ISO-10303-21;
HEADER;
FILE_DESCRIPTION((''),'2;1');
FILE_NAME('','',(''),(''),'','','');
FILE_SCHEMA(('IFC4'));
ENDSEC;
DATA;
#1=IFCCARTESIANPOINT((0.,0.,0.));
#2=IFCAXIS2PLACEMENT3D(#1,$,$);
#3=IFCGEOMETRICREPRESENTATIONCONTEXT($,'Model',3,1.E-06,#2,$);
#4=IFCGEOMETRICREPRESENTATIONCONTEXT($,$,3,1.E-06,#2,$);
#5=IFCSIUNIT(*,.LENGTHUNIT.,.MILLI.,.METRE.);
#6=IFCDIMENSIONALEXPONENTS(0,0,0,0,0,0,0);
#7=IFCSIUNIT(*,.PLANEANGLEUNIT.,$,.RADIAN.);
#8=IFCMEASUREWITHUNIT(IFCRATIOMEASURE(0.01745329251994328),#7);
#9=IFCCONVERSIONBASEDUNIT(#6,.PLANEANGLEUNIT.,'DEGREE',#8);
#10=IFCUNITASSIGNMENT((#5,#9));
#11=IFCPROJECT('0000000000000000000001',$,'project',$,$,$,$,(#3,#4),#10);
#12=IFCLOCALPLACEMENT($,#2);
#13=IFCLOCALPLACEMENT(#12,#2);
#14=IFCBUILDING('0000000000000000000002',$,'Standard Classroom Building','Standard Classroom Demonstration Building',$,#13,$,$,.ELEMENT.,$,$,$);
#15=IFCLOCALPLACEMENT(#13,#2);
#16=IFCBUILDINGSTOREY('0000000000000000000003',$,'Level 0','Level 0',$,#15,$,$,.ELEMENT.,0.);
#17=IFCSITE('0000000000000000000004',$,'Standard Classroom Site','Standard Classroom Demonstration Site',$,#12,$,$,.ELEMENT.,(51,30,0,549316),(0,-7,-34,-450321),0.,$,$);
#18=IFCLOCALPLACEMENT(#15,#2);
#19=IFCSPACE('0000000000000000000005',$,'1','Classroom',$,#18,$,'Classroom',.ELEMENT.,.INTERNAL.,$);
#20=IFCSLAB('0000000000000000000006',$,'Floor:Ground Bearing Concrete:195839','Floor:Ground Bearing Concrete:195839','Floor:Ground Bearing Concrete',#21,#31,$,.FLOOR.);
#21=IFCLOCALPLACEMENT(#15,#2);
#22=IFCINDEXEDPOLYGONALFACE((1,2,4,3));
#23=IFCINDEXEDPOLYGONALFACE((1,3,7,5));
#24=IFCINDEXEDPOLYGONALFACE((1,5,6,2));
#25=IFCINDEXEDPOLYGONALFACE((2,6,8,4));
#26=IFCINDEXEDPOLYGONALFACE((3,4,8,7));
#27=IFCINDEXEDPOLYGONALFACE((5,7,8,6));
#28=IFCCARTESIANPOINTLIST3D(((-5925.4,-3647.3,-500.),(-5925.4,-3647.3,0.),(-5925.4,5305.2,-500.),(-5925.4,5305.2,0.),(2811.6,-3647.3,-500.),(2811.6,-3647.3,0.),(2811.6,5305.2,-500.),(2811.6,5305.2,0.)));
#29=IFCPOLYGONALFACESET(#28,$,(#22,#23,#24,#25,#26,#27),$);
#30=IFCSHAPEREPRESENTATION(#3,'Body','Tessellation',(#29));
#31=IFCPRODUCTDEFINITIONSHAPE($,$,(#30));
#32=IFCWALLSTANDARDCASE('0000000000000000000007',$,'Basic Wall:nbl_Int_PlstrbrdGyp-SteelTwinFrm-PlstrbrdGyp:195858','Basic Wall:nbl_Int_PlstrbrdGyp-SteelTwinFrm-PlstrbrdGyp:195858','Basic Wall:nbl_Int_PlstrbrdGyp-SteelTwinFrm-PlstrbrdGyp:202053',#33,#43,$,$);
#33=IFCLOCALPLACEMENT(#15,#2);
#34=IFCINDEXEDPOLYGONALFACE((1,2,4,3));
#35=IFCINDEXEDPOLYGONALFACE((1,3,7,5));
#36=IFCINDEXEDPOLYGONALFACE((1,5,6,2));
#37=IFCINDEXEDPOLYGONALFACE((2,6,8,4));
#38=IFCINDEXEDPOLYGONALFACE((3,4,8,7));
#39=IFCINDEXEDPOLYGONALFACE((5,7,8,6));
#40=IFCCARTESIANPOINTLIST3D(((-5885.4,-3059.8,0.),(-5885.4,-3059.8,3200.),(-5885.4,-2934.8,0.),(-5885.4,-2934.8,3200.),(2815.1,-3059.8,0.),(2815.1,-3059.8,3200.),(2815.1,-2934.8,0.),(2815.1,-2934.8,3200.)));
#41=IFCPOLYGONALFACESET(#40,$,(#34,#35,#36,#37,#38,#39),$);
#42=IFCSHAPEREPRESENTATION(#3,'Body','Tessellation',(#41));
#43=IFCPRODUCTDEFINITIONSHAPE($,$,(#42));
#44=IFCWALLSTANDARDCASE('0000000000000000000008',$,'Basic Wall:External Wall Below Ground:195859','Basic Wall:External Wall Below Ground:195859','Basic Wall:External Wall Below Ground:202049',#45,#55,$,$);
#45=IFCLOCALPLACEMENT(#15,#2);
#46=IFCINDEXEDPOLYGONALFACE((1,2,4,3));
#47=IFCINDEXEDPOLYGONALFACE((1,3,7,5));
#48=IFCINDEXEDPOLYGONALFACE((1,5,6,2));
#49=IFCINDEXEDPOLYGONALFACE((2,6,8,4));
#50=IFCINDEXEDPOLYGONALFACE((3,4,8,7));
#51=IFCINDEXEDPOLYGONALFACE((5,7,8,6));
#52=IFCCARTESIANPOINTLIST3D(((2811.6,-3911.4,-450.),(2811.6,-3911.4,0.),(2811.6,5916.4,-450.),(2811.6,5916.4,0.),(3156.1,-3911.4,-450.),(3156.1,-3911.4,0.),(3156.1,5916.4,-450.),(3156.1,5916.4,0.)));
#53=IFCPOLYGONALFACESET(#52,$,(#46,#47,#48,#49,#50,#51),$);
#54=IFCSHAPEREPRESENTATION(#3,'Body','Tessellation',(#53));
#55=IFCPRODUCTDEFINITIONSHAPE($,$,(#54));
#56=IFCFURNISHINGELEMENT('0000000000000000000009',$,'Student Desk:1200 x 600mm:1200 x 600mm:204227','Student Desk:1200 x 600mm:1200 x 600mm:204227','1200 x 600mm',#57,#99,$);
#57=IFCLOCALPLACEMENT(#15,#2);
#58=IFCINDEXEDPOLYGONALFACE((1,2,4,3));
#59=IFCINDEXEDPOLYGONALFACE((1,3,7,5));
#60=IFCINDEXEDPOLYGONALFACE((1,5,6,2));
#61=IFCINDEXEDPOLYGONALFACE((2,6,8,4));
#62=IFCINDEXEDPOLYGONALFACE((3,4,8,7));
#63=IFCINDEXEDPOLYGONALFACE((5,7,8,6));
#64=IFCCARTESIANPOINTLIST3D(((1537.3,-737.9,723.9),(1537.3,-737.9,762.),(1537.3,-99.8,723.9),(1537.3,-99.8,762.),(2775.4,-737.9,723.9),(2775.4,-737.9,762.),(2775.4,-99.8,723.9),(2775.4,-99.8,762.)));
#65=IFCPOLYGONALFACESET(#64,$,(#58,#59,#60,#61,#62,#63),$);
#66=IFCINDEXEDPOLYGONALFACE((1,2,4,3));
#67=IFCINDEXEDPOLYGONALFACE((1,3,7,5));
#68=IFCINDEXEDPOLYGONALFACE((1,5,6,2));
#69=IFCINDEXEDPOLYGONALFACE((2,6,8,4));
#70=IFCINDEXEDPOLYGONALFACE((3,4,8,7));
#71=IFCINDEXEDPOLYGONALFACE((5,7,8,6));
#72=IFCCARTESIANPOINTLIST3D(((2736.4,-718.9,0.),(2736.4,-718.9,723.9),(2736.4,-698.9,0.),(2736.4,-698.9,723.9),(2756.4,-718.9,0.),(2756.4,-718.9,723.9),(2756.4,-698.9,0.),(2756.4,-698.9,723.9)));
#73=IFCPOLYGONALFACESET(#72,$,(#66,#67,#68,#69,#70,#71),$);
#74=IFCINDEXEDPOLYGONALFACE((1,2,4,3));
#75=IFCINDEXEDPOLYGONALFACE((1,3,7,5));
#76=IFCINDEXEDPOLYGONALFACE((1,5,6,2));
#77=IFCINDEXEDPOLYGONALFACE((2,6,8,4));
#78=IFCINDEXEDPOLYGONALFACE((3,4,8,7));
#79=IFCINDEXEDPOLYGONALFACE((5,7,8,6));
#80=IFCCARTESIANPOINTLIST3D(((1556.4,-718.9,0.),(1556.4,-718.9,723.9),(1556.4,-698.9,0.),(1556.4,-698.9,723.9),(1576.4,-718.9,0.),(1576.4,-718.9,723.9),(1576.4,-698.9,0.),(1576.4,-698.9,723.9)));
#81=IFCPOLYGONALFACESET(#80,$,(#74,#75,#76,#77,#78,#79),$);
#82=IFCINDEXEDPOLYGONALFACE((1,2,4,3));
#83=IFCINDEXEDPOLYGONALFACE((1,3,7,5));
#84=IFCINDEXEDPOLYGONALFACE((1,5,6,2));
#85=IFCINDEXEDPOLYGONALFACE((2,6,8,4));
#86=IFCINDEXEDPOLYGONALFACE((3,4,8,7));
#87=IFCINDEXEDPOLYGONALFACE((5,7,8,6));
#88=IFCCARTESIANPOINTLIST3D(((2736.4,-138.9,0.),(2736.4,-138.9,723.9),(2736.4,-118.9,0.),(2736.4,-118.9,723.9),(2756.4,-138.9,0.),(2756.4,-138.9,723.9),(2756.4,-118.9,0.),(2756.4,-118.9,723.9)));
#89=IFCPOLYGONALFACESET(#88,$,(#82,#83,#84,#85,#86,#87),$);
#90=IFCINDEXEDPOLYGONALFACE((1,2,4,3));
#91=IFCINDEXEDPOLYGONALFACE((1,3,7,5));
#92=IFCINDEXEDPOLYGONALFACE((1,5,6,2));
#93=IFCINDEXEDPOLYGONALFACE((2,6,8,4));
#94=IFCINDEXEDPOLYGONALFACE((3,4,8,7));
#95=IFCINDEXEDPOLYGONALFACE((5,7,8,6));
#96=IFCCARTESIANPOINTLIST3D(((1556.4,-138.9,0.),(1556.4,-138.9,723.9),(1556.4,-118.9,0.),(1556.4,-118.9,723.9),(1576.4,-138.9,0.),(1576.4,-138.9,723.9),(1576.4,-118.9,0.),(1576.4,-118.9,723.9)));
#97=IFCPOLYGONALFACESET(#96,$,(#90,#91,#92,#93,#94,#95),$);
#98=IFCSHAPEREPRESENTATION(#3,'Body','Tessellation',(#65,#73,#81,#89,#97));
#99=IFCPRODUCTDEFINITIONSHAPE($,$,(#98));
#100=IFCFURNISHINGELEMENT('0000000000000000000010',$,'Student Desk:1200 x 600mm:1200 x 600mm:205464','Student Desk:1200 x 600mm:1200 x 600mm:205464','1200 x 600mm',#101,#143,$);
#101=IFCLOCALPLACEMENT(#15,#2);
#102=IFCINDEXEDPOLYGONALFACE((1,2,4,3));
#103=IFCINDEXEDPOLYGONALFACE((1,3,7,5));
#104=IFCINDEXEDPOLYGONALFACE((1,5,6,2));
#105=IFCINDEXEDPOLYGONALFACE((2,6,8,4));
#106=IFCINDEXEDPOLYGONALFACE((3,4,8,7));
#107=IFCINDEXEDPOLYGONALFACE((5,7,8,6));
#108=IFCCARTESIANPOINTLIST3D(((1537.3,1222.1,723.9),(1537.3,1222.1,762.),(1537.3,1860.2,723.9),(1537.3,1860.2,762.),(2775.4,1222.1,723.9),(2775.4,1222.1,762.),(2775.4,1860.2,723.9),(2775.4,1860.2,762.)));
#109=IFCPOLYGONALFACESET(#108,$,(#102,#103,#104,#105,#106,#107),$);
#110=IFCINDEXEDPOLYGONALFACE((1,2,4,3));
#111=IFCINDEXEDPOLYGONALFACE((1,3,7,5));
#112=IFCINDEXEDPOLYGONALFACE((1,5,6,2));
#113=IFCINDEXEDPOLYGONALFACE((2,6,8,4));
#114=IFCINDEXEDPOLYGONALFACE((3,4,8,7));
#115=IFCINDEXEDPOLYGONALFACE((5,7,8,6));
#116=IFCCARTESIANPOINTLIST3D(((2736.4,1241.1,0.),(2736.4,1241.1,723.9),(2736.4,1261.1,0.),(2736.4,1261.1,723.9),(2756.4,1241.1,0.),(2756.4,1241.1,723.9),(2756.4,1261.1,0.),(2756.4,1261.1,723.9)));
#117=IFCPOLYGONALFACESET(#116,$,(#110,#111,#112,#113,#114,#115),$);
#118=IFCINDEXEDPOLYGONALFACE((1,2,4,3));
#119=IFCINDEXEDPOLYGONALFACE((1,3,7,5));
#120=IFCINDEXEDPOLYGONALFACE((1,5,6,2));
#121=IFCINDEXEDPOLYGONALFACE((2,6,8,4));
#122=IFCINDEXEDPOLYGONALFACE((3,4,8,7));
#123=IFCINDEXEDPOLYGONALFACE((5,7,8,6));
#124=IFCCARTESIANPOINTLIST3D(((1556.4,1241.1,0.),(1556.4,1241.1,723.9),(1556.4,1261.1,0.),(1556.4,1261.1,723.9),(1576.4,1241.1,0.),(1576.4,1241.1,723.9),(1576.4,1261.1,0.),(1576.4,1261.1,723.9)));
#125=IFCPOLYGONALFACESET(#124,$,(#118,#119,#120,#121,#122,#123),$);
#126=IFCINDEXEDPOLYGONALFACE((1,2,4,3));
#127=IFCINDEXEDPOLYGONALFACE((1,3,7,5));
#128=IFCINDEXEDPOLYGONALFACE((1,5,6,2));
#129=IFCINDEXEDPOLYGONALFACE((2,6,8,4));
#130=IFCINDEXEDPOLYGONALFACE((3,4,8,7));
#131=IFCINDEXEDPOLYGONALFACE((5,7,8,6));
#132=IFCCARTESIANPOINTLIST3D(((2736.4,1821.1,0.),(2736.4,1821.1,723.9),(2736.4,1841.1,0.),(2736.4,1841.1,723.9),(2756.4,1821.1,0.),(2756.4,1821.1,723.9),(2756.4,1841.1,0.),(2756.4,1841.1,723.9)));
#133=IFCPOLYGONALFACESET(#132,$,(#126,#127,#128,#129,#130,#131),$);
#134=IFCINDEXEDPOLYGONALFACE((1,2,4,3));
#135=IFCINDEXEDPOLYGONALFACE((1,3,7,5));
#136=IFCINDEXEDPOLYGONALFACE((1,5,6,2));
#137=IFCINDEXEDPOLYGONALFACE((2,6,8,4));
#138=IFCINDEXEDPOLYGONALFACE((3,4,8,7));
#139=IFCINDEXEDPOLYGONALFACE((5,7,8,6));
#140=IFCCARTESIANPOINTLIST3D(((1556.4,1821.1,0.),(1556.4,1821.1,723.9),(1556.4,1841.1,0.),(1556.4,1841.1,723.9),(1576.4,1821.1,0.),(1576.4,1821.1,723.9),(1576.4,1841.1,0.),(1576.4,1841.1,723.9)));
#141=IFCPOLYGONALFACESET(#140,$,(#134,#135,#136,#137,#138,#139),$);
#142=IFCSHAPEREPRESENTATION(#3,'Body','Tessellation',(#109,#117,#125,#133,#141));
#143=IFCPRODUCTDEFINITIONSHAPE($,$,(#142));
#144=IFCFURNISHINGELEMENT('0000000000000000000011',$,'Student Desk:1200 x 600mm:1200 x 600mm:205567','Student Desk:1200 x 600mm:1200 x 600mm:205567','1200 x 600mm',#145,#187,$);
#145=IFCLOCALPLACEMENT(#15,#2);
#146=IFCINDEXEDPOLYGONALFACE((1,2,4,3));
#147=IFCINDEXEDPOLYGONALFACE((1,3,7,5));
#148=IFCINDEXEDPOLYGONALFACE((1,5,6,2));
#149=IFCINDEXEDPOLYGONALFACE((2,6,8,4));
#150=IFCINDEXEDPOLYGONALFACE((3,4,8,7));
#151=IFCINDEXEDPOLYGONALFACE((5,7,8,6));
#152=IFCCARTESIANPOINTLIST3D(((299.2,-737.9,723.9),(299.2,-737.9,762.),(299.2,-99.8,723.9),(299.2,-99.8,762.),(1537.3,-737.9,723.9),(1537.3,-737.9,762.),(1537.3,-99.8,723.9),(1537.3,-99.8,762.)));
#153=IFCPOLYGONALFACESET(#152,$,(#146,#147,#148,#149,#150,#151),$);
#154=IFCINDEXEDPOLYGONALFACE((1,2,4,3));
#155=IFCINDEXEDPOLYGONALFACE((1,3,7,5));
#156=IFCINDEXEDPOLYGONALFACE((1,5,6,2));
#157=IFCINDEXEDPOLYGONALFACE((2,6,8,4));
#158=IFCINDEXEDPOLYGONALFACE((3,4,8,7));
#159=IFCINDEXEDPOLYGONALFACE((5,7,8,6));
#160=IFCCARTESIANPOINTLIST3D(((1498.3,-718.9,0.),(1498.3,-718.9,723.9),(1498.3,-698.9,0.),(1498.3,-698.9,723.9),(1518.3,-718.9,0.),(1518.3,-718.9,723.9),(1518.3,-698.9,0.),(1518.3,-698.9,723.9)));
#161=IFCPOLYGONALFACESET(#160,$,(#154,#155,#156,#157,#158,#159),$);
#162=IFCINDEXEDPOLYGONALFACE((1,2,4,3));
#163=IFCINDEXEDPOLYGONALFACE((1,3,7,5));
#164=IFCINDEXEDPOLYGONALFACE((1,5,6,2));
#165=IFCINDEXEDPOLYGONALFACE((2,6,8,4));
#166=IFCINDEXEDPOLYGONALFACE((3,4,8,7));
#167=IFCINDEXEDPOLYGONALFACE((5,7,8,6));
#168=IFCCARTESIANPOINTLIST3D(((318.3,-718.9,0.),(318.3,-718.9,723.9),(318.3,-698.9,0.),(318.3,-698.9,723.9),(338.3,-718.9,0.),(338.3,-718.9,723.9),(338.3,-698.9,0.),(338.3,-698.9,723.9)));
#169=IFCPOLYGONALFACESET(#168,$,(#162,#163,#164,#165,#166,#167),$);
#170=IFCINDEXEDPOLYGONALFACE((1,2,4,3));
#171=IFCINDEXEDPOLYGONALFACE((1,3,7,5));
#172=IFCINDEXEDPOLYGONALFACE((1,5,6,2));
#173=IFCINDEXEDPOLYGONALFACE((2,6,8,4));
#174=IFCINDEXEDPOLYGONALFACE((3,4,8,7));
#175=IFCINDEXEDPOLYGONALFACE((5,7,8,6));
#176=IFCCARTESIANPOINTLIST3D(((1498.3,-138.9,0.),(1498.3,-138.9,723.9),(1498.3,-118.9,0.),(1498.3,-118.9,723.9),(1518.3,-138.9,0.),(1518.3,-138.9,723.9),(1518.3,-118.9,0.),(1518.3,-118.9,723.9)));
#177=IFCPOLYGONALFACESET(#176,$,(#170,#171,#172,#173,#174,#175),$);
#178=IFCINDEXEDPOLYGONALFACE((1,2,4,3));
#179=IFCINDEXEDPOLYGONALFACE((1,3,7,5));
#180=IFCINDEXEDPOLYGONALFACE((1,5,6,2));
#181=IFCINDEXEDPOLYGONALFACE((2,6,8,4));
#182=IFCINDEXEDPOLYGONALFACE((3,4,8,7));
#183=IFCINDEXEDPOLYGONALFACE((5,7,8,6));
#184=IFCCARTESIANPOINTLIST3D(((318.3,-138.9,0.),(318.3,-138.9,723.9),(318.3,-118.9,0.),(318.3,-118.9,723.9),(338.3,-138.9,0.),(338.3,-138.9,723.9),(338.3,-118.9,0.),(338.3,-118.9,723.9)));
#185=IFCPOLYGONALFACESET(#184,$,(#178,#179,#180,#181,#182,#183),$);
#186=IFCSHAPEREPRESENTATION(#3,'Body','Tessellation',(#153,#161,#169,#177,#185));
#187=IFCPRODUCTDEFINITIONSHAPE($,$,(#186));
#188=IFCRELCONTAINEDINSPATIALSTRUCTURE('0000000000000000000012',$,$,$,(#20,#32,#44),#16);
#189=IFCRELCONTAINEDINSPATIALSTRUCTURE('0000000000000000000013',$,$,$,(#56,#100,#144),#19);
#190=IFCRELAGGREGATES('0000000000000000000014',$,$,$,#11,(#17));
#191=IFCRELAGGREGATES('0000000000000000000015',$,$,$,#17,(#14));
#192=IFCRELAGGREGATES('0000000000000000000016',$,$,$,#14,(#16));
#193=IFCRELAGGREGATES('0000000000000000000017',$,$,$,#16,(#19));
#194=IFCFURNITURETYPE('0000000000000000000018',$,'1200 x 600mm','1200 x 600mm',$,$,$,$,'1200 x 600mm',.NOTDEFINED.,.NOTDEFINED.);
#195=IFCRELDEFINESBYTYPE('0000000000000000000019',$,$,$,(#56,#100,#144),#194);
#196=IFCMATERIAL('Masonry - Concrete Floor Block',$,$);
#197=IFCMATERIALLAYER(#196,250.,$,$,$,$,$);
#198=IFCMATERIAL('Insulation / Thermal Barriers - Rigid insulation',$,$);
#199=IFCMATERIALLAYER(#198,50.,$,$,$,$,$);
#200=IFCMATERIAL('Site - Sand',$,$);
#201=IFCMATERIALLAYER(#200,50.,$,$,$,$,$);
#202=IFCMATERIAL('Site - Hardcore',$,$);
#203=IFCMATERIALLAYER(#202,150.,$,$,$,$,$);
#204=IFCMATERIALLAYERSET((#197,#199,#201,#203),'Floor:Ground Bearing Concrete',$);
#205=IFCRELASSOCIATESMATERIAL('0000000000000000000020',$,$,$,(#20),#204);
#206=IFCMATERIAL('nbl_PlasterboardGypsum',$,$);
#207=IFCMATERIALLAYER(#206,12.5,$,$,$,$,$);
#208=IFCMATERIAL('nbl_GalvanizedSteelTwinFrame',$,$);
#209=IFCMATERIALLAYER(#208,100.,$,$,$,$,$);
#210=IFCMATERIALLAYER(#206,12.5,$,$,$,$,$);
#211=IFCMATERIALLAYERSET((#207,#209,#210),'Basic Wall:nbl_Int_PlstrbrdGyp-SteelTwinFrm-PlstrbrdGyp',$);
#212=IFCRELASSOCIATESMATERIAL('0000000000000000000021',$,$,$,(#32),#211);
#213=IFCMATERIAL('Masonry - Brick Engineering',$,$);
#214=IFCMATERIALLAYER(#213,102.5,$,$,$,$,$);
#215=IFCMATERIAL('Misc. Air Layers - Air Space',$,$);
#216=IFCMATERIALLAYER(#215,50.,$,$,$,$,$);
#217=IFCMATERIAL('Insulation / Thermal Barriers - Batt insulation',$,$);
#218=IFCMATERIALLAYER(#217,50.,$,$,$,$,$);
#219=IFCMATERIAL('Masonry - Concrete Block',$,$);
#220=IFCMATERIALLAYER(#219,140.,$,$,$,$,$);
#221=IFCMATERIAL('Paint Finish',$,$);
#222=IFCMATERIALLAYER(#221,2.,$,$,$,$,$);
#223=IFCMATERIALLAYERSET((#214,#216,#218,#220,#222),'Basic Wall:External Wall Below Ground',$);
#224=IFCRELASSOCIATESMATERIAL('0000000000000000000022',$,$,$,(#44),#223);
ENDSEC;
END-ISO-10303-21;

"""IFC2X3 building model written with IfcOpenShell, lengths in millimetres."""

from ifc_helpers import new_model, entity, si_unit, converted_unit, frame, frame_2d, origin, origin_2d_with_axis, place, context, project, spatial, polyline, rectangle, extrude, clip, bounded_halfspace, source, transform, mapped, material, layer, layer_set, layer_usage, type_object, type_shapes, element, save


model = new_model("IFC2X3")

# Units and contexts
model_context = context("Model", 3, precision=1e-06, world=origin())
context_of_model = context(None, 3, precision=1e-06, world=origin())
ifc_project = project(units=[si_unit("LENGTHUNIT", "METRE", prefix="MILLI"), converted_unit("PLANEANGLEUNIT", "DEGREE", entity("IfcRatioMeasure", 0.01745329251994328), si_unit("PLANEANGLEUNIT", "RADIAN"), dimensions=[0, 0, 0, 0, 0, 0, 0])], contexts=[model_context, context_of_model])

# Site, building, storey
site_placement = place(None, origin())
site = spatial("IfcSite", under=ifc_project, at=site_placement, Name="Standard Classroom Site", Description="Standard Classroom Demonstration Site", CompositionType="ELEMENT", RefLatitude=(51, 30, 0, 549316), RefLongitude=(0, -7, -34, -450321), RefElevation=0.0)
building_placement = place(site_placement, origin())
building = spatial("IfcBuilding", under=site, at=building_placement, Name="Standard Classroom Building", Description="Standard Classroom Demonstration Building", CompositionType="ELEMENT")
storey_placement = place(building_placement, origin())
storey = spatial("IfcBuildingStorey", under=building, at=storey_placement, Name="Level 0", Description="Level 0", CompositionType="ELEMENT", Elevation=0.0)

# Slab
ifc_material_1 = material(Name="Masonry - Concrete Floor Block")
ifc_layer_1 = layer(ifc_material_1, 250.0)
ifc_material_2 = material(Name="Insulation / Thermal Barriers - Rigid insulation")
ifc_layer_2 = layer(ifc_material_2, 50.0)
ifc_material_3 = material(Name="Site - Sand")
ifc_layer_3 = layer(ifc_material_3, 50.0)
ifc_material_4 = material(Name="Site - Hardcore")
ifc_layer_4 = layer(ifc_material_4, 150.0)
ifc_layer_set_1 = layer_set([ifc_layer_1, ifc_layer_2, ifc_layer_3, ifc_layer_4], Name="Floor:Ground Bearing Concrete")
ifc_layer_usage_1 = layer_usage(ifc_layer_set_1, "AXIS3", "POSITIVE", 0.0)
slab_placement = place(storey_placement, frame((-5925.4, -3647.3, -500.0)))
element("IfcSlab", 1, at=slab_placement, inside=storey, material=ifc_layer_usage_1, Name="Floor:Ground Bearing Concrete:195839", Description="Floor:Ground Bearing Concrete:195839", ObjectType="Floor:Ground Bearing Concrete", PredefinedType="FLOOR", context=model_context, shape_type="SweptSolid", body=[
    extrude(rectangle(XDim=8952.5, YDim=8737.0, at=frame_2d((0.0, 0.0), x_axis=(0.0, -1.0))), frame((4368.5, 4476.3, 500.0), z_axis=(0.0, 0.0, -1.0), x_axis=(-1.0, 0.0, 0.0)), (0.0, 0.0, 1.0), 500.0),
])

# Walls
ifc_material_5 = material(Name="nbl_PlasterboardGypsum")
ifc_layer_5 = layer(ifc_material_5, 12.5)
ifc_material_6 = material(Name="nbl_GalvanizedSteelTwinFrame")
ifc_layer_6 = layer(ifc_material_6, 100.0)
ifc_layer_7 = layer(ifc_material_5, 12.5)
ifc_layer_set_2 = layer_set([ifc_layer_5, ifc_layer_6, ifc_layer_7], Name="Basic Wall:nbl_Int_PlstrbrdGyp-SteelTwinFrm-PlstrbrdGyp")
ifc_layer_usage_2 = layer_usage(ifc_layer_set_2, "AXIS2", "POSITIVE", -62.5)
wall_1_placement = place(storey_placement, frame((-5885.4, -2997.3, 0.0)))
element("IfcWallStandardCase", 2, at=wall_1_placement, inside=storey, material=ifc_layer_usage_2, Name="Basic Wall:nbl_Int_PlstrbrdGyp-SteelTwinFrm-PlstrbrdGyp:195858", Description="Basic Wall:nbl_Int_PlstrbrdGyp-SteelTwinFrm-PlstrbrdGyp:195858", ObjectType="Basic Wall:nbl_Int_PlstrbrdGyp-SteelTwinFrm-PlstrbrdGyp:202053", context=model_context, shape_type="Clipping", body=[
    clip(extrude(rectangle(XDim=8700.5, YDim=125.0, at=frame_2d((4350.3, 0.0), x_axis=(-1.0, 0.0))), origin(), (0.0, 0.0, 1.0), 3200.0), bounded_halfspace(frame((0.0, -62.5, 3200.0), z_axis=(0.0, 0.0, -1.0), x_axis=(0.0, -1.0, 0.0)), True, frame((0.0, -62.5, 3200.0)), polyline([(0.0, 0.0), (8700.5, 0.0), (8700.5, 125.0), (901.0, 125.0), (776.0, 125.0), (0.0, 125.0), (0.0, 0.0)]))),
])
ifc_material_7 = material(Name="Masonry - Brick Engineering")
ifc_layer_8 = layer(ifc_material_7, 102.5)
ifc_material_8 = material(Name="Misc. Air Layers - Air Space")
ifc_layer_9 = layer(ifc_material_8, 50.0)
ifc_material_9 = material(Name="Insulation / Thermal Barriers - Batt insulation")
ifc_layer_10 = layer(ifc_material_9, 50.0)
ifc_material_10 = material(Name="Masonry - Concrete Block")
ifc_layer_11 = layer(ifc_material_10, 140.0)
ifc_material_11 = material(Name="Paint Finish")
ifc_layer_12 = layer(ifc_material_11, 2.0)
ifc_layer_set_3 = layer_set([ifc_layer_8, ifc_layer_9, ifc_layer_10, ifc_layer_11, ifc_layer_12], Name="Basic Wall:External Wall Below Ground")
ifc_layer_usage_3 = layer_usage(ifc_layer_set_3, "AXIS2", "POSITIVE", -172.2)
wall_2_placement = place(storey_placement, frame((2983.9, -3911.4, -450.0), z_axis=(0.0, 0.0, 1.0), x_axis=(0.0, 1.0, 0.0)))
element("IfcWallStandardCase", 3, at=wall_2_placement, inside=storey, material=ifc_layer_usage_3, Name="Basic Wall:External Wall Below Ground:195859", Description="Basic Wall:External Wall Below Ground:195859", ObjectType="Basic Wall:External Wall Below Ground:202049", context=model_context, shape_type="SweptSolid", body=[
    extrude(rectangle(XDim=9827.8, YDim=344.5, at=frame_2d((4913.9, 0.0), x_axis=(-1.0, 0.0))), origin(), (0.0, 0.0, 1.0), 450.0),
])

# Shared definitions
space_placement = place(storey_placement, origin())
space = spatial("IfcSpace", under=storey, at=space_placement, Name="1", Description="Classroom", LongName="Classroom", CompositionType="ELEMENT", InteriorOrExteriorSpace="INTERNAL")

# Furnishing elements
furniture_type = type_object("IfcFurnitureType", Name="1200 x 600mm", Description="1200 x 600mm", ElementType="1200 x 600mm", AssemblyPlace="NOTDEFINED")
shared_shape_1 = source(origin(), model_context, "Body", "SweptSolid", [
    extrude(rectangle(XDim=1238.1, YDim=638.1, at=origin_2d_with_axis()), frame((600.0, 300.0, 723.9), z_axis=(0.0, 0.0, 1.0), x_axis=(-1.0, 0.0, 0.0)), (0.0, 0.0, 1.0), 38.1),
    extrude(rectangle(XDim=20.0, YDim=20.0, at=origin_2d_with_axis()), frame((1190.0, 10.0, 0.0)), (0.0, 0.0, 1.0), 723.9),
    extrude(rectangle(XDim=20.0, YDim=20.0, at=origin_2d_with_axis()), frame((10.0, 10.0, 0.0), z_axis=(0.0, 0.0, 1.0), x_axis=(0.0, 1.0, 0.0)), (0.0, 0.0, 1.0), 723.9),
    extrude(rectangle(XDim=20.0, YDim=20.0, at=origin_2d_with_axis()), frame((1190.0, 590.0, 0.0), z_axis=(0.0, 0.0, 1.0), x_axis=(0.0, -1.0, 0.0)), (0.0, 0.0, 1.0), 723.9),
    extrude(rectangle(XDim=20.0, YDim=20.0, at=origin_2d_with_axis()), frame((10.0, 590.0, 0.0), z_axis=(0.0, 0.0, 1.0), x_axis=(-1.0, 0.0, 0.0)), (0.0, 0.0, 1.0), 723.9),
])
type_shapes(furniture_type, [shared_shape_1])
for number, where, name, description in (
    (4, (1556.4, -718.9, 0.0), "Student Desk:1200 x 600mm:1200 x 600mm:204227", "Student Desk:1200 x 600mm:1200 x 600mm:204227"),
    (5, (1556.4, 1241.1, 0.0), "Student Desk:1200 x 600mm:1200 x 600mm:205464", "Student Desk:1200 x 600mm:1200 x 600mm:205464"),
    (6, (318.3, -718.9, 0.0), "Student Desk:1200 x 600mm:1200 x 600mm:205567", "Student Desk:1200 x 600mm:1200 x 600mm:205567"),
):
    element("IfcFurnishingElement", number, at=place(space_placement, frame(where)), inside=space, type_object=furniture_type, Name=name, Description=description, ObjectType="1200 x 600mm", context=model_context, shape_type="MappedRepresentation", body=[
        mapped(shared_shape_1, transform((0.0, 0.0, 0.0), scale=1.0)),
    ])

save(model, "model.ifc")
